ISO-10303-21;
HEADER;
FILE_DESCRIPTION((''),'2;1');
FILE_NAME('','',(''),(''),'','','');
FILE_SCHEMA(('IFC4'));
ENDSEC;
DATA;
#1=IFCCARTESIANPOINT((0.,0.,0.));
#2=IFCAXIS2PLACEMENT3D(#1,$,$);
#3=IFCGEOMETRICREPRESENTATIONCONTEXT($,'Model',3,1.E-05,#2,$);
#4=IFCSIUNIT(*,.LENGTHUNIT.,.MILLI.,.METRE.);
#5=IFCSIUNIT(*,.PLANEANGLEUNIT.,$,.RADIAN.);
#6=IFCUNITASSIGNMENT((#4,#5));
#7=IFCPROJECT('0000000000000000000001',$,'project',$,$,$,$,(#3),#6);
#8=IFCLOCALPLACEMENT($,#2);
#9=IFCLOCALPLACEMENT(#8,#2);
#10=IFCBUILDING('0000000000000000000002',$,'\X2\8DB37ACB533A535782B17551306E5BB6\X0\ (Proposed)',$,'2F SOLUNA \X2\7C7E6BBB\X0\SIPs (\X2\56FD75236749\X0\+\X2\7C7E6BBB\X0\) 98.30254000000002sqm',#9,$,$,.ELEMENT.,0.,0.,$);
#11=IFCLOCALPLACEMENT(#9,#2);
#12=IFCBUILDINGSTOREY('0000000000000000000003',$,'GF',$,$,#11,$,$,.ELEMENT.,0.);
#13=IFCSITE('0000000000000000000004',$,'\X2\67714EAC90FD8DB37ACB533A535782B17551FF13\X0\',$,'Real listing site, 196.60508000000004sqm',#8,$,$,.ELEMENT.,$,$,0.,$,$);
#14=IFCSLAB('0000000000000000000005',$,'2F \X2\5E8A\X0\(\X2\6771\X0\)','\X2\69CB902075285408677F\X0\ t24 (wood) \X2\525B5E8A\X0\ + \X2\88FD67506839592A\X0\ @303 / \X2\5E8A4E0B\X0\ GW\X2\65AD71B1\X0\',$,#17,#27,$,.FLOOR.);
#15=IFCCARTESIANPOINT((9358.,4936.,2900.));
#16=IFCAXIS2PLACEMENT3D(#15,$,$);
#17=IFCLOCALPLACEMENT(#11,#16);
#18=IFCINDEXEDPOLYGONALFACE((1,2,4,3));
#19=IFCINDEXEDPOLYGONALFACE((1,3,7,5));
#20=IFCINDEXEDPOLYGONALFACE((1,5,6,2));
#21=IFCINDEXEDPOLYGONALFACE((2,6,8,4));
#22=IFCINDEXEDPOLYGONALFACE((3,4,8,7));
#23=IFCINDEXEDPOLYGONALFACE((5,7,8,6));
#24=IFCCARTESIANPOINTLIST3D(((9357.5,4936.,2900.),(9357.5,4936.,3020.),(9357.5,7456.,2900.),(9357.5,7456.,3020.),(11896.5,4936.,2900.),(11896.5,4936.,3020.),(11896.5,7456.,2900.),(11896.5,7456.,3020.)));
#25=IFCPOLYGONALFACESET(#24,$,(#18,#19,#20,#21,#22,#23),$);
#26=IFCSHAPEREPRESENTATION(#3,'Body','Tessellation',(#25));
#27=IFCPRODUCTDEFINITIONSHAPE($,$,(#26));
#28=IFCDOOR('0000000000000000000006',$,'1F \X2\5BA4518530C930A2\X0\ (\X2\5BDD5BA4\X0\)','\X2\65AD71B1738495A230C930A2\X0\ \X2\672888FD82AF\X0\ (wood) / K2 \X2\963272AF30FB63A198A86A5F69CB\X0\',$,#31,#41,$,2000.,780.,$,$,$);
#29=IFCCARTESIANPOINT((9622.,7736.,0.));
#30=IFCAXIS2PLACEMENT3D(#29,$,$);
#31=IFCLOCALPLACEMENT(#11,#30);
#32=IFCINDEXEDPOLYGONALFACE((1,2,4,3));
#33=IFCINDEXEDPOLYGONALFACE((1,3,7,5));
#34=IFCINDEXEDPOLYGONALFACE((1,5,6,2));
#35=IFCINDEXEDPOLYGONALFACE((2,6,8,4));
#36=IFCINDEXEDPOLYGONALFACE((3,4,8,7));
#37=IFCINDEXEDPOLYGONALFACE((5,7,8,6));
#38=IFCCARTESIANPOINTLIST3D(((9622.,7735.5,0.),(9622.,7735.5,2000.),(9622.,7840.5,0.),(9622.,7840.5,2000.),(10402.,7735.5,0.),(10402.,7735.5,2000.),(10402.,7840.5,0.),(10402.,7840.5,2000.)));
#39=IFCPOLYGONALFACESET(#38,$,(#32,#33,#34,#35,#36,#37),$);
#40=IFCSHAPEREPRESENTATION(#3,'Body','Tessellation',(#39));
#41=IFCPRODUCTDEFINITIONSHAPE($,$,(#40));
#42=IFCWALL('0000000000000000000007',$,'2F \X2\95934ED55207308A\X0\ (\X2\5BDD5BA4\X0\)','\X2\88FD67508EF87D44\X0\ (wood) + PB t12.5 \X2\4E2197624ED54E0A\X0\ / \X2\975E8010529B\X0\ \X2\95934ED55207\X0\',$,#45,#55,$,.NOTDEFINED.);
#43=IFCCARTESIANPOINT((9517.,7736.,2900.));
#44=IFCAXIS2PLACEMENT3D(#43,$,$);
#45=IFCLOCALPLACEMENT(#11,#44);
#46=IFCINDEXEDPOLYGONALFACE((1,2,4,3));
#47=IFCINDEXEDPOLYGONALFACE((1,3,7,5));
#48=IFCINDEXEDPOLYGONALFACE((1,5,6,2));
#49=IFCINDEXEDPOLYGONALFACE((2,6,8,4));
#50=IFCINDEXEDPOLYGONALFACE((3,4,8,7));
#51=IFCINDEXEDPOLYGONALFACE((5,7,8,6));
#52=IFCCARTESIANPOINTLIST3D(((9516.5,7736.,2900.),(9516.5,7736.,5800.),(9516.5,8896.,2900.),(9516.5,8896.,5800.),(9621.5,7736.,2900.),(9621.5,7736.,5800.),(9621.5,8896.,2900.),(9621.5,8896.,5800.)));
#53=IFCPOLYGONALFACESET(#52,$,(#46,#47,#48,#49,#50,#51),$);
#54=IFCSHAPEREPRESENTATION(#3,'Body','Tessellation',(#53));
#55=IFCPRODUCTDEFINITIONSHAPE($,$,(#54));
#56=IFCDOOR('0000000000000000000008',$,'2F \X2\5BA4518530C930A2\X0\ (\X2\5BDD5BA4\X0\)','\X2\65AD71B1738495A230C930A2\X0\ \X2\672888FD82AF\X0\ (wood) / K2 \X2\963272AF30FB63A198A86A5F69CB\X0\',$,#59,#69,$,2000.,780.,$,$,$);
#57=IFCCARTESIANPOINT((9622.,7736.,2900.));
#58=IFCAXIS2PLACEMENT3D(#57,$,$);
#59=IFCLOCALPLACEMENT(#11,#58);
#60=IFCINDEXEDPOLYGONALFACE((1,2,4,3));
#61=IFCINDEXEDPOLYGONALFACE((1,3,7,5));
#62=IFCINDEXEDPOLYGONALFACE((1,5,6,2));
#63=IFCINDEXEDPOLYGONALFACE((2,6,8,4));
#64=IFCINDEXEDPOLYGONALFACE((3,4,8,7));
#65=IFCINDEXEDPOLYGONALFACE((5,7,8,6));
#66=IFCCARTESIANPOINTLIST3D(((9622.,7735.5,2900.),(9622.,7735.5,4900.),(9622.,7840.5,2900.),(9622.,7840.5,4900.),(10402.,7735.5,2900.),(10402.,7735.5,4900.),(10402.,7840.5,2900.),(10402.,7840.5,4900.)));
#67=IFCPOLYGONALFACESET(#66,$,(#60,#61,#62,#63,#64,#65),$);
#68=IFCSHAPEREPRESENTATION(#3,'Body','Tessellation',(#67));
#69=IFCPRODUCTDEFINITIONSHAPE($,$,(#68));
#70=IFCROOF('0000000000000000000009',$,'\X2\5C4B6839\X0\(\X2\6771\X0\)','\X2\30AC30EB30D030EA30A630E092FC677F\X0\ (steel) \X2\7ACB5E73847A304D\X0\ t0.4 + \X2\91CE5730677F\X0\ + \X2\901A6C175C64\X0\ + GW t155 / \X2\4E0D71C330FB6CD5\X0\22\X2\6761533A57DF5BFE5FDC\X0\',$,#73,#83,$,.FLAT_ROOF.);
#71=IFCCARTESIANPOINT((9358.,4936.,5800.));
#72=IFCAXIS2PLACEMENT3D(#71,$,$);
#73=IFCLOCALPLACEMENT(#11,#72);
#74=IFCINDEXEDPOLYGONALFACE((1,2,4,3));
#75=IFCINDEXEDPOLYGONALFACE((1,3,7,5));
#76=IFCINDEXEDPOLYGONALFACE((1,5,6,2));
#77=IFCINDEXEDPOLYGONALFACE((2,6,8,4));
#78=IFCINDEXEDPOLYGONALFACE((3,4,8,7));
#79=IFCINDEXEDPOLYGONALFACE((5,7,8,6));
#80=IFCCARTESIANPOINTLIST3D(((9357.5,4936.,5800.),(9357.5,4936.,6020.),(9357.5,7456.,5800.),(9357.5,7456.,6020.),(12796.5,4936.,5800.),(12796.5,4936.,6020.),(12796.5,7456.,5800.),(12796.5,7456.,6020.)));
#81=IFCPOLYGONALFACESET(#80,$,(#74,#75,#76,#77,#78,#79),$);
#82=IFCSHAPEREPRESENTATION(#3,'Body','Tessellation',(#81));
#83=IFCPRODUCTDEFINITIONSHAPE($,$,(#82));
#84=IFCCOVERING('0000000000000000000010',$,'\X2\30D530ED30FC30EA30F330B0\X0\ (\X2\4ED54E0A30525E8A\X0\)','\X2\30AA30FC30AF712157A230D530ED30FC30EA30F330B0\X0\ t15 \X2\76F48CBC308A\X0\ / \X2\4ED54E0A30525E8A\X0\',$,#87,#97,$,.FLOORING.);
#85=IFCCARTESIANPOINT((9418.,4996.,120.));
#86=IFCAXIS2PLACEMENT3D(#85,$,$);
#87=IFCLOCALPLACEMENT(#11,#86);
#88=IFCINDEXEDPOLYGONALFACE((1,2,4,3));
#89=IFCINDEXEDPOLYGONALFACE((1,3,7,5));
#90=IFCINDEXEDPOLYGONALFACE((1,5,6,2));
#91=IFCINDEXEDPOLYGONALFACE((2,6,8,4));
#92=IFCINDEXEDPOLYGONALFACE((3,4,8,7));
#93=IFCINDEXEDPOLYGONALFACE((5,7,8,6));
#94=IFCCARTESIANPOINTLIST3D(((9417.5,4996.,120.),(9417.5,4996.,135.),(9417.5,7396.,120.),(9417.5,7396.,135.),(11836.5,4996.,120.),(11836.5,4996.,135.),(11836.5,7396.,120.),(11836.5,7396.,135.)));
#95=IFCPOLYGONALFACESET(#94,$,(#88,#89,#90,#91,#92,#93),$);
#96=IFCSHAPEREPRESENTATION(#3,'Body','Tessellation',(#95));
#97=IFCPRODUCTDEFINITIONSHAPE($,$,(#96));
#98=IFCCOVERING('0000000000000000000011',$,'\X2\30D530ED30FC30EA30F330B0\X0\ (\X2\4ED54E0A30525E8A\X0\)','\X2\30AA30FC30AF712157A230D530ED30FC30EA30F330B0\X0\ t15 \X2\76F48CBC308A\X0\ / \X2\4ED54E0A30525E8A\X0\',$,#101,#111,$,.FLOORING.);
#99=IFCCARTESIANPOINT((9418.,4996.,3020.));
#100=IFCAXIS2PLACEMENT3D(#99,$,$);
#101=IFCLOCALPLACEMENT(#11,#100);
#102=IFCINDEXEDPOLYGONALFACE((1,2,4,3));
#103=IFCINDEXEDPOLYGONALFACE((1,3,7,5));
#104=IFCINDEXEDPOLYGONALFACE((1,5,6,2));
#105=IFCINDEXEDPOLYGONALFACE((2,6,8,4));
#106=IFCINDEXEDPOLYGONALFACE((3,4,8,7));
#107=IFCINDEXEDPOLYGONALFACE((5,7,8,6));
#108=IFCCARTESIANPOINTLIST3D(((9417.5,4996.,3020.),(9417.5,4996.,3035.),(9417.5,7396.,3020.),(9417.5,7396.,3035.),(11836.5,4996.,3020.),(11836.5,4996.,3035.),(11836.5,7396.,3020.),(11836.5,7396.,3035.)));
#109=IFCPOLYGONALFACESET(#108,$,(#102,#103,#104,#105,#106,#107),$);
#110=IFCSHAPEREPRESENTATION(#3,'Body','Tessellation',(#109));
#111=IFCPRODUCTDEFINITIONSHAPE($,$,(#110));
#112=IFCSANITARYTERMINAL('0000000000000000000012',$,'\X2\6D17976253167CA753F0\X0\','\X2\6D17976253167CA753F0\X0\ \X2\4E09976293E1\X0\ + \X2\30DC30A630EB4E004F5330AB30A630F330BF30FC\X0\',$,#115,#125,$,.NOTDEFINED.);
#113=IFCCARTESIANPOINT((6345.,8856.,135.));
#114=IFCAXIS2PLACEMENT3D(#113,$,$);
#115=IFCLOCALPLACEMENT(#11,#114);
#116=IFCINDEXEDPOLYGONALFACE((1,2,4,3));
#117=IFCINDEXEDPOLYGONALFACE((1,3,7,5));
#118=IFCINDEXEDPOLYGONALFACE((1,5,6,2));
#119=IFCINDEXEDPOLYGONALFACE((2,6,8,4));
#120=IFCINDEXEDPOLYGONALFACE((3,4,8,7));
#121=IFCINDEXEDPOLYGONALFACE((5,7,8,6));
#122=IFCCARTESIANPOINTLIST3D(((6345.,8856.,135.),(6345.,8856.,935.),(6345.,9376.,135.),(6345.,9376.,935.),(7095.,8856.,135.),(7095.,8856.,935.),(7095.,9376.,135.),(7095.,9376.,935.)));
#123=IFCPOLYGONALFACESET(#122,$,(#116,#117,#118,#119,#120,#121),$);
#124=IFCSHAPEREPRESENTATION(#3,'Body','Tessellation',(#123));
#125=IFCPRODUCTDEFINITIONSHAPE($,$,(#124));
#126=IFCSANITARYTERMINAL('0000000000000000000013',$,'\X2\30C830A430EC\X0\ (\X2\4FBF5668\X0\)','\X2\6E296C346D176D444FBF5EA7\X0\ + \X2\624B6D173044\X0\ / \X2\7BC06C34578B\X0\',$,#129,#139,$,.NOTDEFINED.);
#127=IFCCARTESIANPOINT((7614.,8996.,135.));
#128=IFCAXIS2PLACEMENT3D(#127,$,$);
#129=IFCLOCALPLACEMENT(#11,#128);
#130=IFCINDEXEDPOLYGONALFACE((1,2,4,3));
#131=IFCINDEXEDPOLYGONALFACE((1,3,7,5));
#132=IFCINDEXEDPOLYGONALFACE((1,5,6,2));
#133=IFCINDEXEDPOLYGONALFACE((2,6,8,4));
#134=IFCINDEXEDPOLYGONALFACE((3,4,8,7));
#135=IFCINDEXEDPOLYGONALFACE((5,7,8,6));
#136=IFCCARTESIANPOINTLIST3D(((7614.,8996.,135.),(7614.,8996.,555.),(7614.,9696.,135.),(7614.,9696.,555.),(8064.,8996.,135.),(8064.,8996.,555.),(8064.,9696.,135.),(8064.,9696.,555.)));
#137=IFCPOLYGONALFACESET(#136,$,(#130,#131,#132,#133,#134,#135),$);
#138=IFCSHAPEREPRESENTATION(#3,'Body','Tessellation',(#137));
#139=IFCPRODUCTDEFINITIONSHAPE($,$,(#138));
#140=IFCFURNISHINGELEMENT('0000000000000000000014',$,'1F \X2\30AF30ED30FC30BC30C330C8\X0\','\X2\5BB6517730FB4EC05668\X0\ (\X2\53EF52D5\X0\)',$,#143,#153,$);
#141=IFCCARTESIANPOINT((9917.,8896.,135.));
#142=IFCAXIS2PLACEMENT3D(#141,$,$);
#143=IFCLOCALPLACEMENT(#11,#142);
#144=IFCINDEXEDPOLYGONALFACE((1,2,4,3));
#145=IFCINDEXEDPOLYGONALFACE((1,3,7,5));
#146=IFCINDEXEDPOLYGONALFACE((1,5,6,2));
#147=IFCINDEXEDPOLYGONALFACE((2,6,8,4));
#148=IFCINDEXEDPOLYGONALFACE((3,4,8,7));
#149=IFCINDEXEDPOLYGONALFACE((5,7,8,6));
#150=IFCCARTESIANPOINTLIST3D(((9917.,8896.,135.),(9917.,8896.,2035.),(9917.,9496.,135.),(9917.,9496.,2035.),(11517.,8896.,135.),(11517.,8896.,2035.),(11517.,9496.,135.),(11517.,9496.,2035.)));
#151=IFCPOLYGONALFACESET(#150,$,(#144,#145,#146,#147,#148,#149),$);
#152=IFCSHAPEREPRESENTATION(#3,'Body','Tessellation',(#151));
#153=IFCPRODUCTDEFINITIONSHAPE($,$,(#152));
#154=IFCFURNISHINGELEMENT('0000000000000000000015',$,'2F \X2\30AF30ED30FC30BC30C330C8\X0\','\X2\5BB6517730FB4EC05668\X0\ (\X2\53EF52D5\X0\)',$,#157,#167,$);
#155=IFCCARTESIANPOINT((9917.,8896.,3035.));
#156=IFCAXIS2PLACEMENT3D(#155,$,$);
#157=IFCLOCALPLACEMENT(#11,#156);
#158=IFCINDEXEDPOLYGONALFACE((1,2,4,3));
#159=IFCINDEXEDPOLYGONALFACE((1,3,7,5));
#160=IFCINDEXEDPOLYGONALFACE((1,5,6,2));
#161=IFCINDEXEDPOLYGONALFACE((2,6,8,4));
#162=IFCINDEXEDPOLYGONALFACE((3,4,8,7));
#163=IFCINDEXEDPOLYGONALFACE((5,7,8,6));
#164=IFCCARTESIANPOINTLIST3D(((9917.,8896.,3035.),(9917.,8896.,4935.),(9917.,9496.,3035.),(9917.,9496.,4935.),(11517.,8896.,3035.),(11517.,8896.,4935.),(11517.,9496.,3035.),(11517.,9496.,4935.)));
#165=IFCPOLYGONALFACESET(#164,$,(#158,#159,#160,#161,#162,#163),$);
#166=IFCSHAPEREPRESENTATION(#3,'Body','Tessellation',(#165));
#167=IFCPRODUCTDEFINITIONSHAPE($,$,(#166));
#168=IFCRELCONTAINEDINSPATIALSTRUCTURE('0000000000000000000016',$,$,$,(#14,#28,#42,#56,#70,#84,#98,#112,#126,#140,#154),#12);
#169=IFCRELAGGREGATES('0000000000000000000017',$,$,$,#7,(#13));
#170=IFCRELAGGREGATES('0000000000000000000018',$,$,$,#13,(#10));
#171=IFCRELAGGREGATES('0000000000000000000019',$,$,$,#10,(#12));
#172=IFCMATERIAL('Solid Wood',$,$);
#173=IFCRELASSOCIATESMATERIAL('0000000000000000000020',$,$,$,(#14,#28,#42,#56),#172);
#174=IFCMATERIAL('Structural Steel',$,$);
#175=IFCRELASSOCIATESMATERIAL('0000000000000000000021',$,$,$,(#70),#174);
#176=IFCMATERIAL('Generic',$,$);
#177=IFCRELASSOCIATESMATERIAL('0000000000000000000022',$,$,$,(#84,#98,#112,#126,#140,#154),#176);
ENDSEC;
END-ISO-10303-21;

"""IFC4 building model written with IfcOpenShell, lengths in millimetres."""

from ifc_helpers import new_model, si_unit, frame, frame_2d, origin, place, context, project, spatial, rectangle, extrude, material, element, save


model = new_model("IFC4")

# Units and contexts
model_context = context("Model", 3, precision=1e-05, world=origin())
ifc_project = project(units=[si_unit("LENGTHUNIT", "METRE", prefix="MILLI"), si_unit("PLANEANGLEUNIT", "RADIAN")], contexts=[model_context])

# Site, building, storey
site_placement = place(None, origin())
site = spatial("IfcSite", under=ifc_project, at=site_placement, Name="東京都足立区南花畑３", ObjectType="Real listing site, 196.60508000000004sqm", CompositionType="ELEMENT", RefElevation=0.0)
building_placement = place(site_placement, origin())
building = spatial("IfcBuilding", under=site, at=building_placement, Name="足立区南花畑の家 (Proposed)", ObjectType="2F SOLUNA 籾殻SIPs (国産杉+籾殻) 98.30254000000002sqm", CompositionType="ELEMENT", ElevationOfRefHeight=0.0, ElevationOfTerrain=0.0)
storey_placement = place(building_placement, origin())
storey = spatial("IfcBuildingStorey", under=building, at=storey_placement, Name="GF", CompositionType="ELEMENT", Elevation=0.0)

# Slab
ifc_material_1 = material(Name="Solid Wood")
slab_1_placement = place(storey_placement, frame((9358.0, 4936.0, 2900.0)))
element("IfcSlab", 1, at=slab_1_placement, inside=storey, material=ifc_material_1, Name="2F 床(東)", Description="構造用合板 t24 (wood) 剛床 + 製材根太 @303 / 床下 GW断熱", PredefinedType="FLOOR", context=model_context, shape_type="SweptSolid", body=[
    extrude(rectangle(XDim=2539.0, YDim=2520.0, at=frame_2d((1269.0, 1260.0))), frame((9358.0, 4936.0, 2900.0)), (0.0, 0.0, 1.0), 120.0),
])

# Door
door_1_placement = place(storey_placement, frame((9622.0, 7736.0, 0.0)))
element("IfcDoor", 2, at=door_1_placement, inside=storey, material=ifc_material_1, Name="1F 室内ドア (寝室)", Description="断熱玄関ドア 木製芯 (wood) / K2 防犯・採風機構", OverallHeight=2000.0, OverallWidth=780.0, context=model_context, shape_type="SweptSolid", body=[
    extrude(rectangle(XDim=780.0, YDim=105.0, at=frame_2d((390.0, 52.0))), frame((9622.0, 7736.0, 0.0)), (0.0, 0.0, 1.0), 2000.0),
])

# Wall
wall_1_placement = place(storey_placement, frame((9517.0, 7736.0, 2900.0)))
element("IfcWall", 3, at=wall_1_placement, inside=storey, material=ifc_material_1, Name="2F 間仕切り (寝室)", Description="製材軸組 (wood) + PB t12.5 両面仕上 / 非耐力 間仕切", PredefinedType="NOTDEFINED", context=model_context, shape_type="SweptSolid", body=[
    extrude(rectangle(XDim=105.0, YDim=1160.0, at=frame_2d((52.0, 580.0))), frame((9517.0, 7736.0, 2900.0)), (0.0, 0.0, 1.0), 2900.0),
])

# Door
door_2_placement = place(storey_placement, frame((9622.0, 7736.0, 2900.0)))
element("IfcDoor", 4, at=door_2_placement, inside=storey, material=ifc_material_1, Name="2F 室内ドア (寝室)", Description="断熱玄関ドア 木製芯 (wood) / K2 防犯・採風機構", OverallHeight=2000.0, OverallWidth=780.0, context=model_context, shape_type="SweptSolid", body=[
    extrude(rectangle(XDim=780.0, YDim=105.0, at=frame_2d((390.0, 52.0))), frame((9622.0, 7736.0, 2900.0)), (0.0, 0.0, 1.0), 2000.0),
])

# Roof
ifc_material_2 = material(Name="Structural Steel")
for number, where, name in (
    (5, (9358.0, 4936.0, 5800.0), "屋根(東)"),
):
    element("IfcRoof", number, at=place(storey_placement, frame(where)), inside=storey, material=ifc_material_2, Name=name, Description="ガルバリウム鋼板 (steel) 立平葺き t0.4 + 野地板 + 通気層 + GW t155 / 不燃・法22条区域対応", PredefinedType="FLAT_ROOF", context=model_context, shape_type="SweptSolid", body=[
        extrude(rectangle(XDim=3439.0, YDim=2520.0, at=frame_2d((1719.0, 1260.0))), frame((9358.0, 4936.0, 5800.0)), (0.0, 0.0, 1.0), 220.0),
    ])

# Coverings
ifc_material_3 = material(Name="Generic")
covering_1_placement = place(storey_placement, frame((9418.0, 4996.0, 120.0)))
element("IfcCovering", 6, at=covering_1_placement, inside=storey, material=ifc_material_3, Name="フローリング (仕上げ床)", Description="オーク無垢フローリング t15 直貼り / 仕上げ床", PredefinedType="FLOORING", context=model_context, shape_type="SweptSolid", body=[
    extrude(rectangle(XDim=2419.0, YDim=2400.0, at=frame_2d((1209.0, 1200.0))), frame((9418.0, 4996.0, 120.0)), (0.0, 0.0, 1.0), 15.0),
])
covering_2_placement = place(storey_placement, frame((9418.0, 4996.0, 3020.0)))
element("IfcCovering", 7, at=covering_2_placement, inside=storey, material=ifc_material_3, Name="フローリング (仕上げ床)", Description="オーク無垢フローリング t15 直貼り / 仕上げ床", PredefinedType="FLOORING", context=model_context, shape_type="SweptSolid", body=[
    extrude(rectangle(XDim=2419.0, YDim=2400.0, at=frame_2d((1209.0, 1200.0))), frame((9418.0, 4996.0, 3020.0)), (0.0, 0.0, 1.0), 15.0),
])

# Sanitary terminals
sanitary_terminal_1_placement = place(storey_placement, frame((6345.0, 8856.0, 135.0)))
element("IfcSanitaryTerminal", 8, at=sanitary_terminal_1_placement, inside=storey, material=ifc_material_3, Name="洗面化粧台", Description="洗面化粧台 三面鏡 + ボウル一体カウンター", PredefinedType="NOTDEFINED", context=model_context, shape_type="SweptSolid", body=[
    extrude(rectangle(XDim=750.0, YDim=520.0, at=frame_2d((375.0, 260.0))), frame((6345.0, 8856.0, 135.0)), (0.0, 0.0, 1.0), 800.0),
])
sanitary_terminal_2_placement = place(storey_placement, frame((7614.0, 8996.0, 135.0)))
element("IfcSanitaryTerminal", 9, at=sanitary_terminal_2_placement, inside=storey, material=ifc_material_3, Name="トイレ (便器)", Description="温水洗浄便座 + 手洗い / 節水型", PredefinedType="NOTDEFINED", context=model_context, shape_type="SweptSolid", body=[
    extrude(rectangle(XDim=450.0, YDim=700.0, at=frame_2d((225.0, 350.0))), frame((7614.0, 8996.0, 135.0)), (0.0, 0.0, 1.0), 420.0),
])

# Furnishing elements
furnishing_1_placement = place(storey_placement, frame((9917.0, 8896.0, 135.0)))
element("IfcFurnishingElement", 10, at=furnishing_1_placement, inside=storey, material=ifc_material_3, Name="1F クローゼット", Description="家具・什器 (可動)", context=model_context, shape_type="SweptSolid", body=[
    extrude(rectangle(XDim=1600.0, YDim=600.0, at=frame_2d((800.0, 300.0))), frame((9917.0, 8896.0, 135.0)), (0.0, 0.0, 1.0), 1900.0),
])
furnishing_2_placement = place(storey_placement, frame((9917.0, 8896.0, 3035.0)))
element("IfcFurnishingElement", 11, at=furnishing_2_placement, inside=storey, material=ifc_material_3, Name="2F クローゼット", Description="家具・什器 (可動)", context=model_context, shape_type="SweptSolid", body=[
    extrude(rectangle(XDim=1600.0, YDim=600.0, at=frame_2d((800.0, 300.0))), frame((9917.0, 8896.0, 3035.0)), (0.0, 0.0, 1.0), 1900.0),
])

save(model, "model.ifc")
